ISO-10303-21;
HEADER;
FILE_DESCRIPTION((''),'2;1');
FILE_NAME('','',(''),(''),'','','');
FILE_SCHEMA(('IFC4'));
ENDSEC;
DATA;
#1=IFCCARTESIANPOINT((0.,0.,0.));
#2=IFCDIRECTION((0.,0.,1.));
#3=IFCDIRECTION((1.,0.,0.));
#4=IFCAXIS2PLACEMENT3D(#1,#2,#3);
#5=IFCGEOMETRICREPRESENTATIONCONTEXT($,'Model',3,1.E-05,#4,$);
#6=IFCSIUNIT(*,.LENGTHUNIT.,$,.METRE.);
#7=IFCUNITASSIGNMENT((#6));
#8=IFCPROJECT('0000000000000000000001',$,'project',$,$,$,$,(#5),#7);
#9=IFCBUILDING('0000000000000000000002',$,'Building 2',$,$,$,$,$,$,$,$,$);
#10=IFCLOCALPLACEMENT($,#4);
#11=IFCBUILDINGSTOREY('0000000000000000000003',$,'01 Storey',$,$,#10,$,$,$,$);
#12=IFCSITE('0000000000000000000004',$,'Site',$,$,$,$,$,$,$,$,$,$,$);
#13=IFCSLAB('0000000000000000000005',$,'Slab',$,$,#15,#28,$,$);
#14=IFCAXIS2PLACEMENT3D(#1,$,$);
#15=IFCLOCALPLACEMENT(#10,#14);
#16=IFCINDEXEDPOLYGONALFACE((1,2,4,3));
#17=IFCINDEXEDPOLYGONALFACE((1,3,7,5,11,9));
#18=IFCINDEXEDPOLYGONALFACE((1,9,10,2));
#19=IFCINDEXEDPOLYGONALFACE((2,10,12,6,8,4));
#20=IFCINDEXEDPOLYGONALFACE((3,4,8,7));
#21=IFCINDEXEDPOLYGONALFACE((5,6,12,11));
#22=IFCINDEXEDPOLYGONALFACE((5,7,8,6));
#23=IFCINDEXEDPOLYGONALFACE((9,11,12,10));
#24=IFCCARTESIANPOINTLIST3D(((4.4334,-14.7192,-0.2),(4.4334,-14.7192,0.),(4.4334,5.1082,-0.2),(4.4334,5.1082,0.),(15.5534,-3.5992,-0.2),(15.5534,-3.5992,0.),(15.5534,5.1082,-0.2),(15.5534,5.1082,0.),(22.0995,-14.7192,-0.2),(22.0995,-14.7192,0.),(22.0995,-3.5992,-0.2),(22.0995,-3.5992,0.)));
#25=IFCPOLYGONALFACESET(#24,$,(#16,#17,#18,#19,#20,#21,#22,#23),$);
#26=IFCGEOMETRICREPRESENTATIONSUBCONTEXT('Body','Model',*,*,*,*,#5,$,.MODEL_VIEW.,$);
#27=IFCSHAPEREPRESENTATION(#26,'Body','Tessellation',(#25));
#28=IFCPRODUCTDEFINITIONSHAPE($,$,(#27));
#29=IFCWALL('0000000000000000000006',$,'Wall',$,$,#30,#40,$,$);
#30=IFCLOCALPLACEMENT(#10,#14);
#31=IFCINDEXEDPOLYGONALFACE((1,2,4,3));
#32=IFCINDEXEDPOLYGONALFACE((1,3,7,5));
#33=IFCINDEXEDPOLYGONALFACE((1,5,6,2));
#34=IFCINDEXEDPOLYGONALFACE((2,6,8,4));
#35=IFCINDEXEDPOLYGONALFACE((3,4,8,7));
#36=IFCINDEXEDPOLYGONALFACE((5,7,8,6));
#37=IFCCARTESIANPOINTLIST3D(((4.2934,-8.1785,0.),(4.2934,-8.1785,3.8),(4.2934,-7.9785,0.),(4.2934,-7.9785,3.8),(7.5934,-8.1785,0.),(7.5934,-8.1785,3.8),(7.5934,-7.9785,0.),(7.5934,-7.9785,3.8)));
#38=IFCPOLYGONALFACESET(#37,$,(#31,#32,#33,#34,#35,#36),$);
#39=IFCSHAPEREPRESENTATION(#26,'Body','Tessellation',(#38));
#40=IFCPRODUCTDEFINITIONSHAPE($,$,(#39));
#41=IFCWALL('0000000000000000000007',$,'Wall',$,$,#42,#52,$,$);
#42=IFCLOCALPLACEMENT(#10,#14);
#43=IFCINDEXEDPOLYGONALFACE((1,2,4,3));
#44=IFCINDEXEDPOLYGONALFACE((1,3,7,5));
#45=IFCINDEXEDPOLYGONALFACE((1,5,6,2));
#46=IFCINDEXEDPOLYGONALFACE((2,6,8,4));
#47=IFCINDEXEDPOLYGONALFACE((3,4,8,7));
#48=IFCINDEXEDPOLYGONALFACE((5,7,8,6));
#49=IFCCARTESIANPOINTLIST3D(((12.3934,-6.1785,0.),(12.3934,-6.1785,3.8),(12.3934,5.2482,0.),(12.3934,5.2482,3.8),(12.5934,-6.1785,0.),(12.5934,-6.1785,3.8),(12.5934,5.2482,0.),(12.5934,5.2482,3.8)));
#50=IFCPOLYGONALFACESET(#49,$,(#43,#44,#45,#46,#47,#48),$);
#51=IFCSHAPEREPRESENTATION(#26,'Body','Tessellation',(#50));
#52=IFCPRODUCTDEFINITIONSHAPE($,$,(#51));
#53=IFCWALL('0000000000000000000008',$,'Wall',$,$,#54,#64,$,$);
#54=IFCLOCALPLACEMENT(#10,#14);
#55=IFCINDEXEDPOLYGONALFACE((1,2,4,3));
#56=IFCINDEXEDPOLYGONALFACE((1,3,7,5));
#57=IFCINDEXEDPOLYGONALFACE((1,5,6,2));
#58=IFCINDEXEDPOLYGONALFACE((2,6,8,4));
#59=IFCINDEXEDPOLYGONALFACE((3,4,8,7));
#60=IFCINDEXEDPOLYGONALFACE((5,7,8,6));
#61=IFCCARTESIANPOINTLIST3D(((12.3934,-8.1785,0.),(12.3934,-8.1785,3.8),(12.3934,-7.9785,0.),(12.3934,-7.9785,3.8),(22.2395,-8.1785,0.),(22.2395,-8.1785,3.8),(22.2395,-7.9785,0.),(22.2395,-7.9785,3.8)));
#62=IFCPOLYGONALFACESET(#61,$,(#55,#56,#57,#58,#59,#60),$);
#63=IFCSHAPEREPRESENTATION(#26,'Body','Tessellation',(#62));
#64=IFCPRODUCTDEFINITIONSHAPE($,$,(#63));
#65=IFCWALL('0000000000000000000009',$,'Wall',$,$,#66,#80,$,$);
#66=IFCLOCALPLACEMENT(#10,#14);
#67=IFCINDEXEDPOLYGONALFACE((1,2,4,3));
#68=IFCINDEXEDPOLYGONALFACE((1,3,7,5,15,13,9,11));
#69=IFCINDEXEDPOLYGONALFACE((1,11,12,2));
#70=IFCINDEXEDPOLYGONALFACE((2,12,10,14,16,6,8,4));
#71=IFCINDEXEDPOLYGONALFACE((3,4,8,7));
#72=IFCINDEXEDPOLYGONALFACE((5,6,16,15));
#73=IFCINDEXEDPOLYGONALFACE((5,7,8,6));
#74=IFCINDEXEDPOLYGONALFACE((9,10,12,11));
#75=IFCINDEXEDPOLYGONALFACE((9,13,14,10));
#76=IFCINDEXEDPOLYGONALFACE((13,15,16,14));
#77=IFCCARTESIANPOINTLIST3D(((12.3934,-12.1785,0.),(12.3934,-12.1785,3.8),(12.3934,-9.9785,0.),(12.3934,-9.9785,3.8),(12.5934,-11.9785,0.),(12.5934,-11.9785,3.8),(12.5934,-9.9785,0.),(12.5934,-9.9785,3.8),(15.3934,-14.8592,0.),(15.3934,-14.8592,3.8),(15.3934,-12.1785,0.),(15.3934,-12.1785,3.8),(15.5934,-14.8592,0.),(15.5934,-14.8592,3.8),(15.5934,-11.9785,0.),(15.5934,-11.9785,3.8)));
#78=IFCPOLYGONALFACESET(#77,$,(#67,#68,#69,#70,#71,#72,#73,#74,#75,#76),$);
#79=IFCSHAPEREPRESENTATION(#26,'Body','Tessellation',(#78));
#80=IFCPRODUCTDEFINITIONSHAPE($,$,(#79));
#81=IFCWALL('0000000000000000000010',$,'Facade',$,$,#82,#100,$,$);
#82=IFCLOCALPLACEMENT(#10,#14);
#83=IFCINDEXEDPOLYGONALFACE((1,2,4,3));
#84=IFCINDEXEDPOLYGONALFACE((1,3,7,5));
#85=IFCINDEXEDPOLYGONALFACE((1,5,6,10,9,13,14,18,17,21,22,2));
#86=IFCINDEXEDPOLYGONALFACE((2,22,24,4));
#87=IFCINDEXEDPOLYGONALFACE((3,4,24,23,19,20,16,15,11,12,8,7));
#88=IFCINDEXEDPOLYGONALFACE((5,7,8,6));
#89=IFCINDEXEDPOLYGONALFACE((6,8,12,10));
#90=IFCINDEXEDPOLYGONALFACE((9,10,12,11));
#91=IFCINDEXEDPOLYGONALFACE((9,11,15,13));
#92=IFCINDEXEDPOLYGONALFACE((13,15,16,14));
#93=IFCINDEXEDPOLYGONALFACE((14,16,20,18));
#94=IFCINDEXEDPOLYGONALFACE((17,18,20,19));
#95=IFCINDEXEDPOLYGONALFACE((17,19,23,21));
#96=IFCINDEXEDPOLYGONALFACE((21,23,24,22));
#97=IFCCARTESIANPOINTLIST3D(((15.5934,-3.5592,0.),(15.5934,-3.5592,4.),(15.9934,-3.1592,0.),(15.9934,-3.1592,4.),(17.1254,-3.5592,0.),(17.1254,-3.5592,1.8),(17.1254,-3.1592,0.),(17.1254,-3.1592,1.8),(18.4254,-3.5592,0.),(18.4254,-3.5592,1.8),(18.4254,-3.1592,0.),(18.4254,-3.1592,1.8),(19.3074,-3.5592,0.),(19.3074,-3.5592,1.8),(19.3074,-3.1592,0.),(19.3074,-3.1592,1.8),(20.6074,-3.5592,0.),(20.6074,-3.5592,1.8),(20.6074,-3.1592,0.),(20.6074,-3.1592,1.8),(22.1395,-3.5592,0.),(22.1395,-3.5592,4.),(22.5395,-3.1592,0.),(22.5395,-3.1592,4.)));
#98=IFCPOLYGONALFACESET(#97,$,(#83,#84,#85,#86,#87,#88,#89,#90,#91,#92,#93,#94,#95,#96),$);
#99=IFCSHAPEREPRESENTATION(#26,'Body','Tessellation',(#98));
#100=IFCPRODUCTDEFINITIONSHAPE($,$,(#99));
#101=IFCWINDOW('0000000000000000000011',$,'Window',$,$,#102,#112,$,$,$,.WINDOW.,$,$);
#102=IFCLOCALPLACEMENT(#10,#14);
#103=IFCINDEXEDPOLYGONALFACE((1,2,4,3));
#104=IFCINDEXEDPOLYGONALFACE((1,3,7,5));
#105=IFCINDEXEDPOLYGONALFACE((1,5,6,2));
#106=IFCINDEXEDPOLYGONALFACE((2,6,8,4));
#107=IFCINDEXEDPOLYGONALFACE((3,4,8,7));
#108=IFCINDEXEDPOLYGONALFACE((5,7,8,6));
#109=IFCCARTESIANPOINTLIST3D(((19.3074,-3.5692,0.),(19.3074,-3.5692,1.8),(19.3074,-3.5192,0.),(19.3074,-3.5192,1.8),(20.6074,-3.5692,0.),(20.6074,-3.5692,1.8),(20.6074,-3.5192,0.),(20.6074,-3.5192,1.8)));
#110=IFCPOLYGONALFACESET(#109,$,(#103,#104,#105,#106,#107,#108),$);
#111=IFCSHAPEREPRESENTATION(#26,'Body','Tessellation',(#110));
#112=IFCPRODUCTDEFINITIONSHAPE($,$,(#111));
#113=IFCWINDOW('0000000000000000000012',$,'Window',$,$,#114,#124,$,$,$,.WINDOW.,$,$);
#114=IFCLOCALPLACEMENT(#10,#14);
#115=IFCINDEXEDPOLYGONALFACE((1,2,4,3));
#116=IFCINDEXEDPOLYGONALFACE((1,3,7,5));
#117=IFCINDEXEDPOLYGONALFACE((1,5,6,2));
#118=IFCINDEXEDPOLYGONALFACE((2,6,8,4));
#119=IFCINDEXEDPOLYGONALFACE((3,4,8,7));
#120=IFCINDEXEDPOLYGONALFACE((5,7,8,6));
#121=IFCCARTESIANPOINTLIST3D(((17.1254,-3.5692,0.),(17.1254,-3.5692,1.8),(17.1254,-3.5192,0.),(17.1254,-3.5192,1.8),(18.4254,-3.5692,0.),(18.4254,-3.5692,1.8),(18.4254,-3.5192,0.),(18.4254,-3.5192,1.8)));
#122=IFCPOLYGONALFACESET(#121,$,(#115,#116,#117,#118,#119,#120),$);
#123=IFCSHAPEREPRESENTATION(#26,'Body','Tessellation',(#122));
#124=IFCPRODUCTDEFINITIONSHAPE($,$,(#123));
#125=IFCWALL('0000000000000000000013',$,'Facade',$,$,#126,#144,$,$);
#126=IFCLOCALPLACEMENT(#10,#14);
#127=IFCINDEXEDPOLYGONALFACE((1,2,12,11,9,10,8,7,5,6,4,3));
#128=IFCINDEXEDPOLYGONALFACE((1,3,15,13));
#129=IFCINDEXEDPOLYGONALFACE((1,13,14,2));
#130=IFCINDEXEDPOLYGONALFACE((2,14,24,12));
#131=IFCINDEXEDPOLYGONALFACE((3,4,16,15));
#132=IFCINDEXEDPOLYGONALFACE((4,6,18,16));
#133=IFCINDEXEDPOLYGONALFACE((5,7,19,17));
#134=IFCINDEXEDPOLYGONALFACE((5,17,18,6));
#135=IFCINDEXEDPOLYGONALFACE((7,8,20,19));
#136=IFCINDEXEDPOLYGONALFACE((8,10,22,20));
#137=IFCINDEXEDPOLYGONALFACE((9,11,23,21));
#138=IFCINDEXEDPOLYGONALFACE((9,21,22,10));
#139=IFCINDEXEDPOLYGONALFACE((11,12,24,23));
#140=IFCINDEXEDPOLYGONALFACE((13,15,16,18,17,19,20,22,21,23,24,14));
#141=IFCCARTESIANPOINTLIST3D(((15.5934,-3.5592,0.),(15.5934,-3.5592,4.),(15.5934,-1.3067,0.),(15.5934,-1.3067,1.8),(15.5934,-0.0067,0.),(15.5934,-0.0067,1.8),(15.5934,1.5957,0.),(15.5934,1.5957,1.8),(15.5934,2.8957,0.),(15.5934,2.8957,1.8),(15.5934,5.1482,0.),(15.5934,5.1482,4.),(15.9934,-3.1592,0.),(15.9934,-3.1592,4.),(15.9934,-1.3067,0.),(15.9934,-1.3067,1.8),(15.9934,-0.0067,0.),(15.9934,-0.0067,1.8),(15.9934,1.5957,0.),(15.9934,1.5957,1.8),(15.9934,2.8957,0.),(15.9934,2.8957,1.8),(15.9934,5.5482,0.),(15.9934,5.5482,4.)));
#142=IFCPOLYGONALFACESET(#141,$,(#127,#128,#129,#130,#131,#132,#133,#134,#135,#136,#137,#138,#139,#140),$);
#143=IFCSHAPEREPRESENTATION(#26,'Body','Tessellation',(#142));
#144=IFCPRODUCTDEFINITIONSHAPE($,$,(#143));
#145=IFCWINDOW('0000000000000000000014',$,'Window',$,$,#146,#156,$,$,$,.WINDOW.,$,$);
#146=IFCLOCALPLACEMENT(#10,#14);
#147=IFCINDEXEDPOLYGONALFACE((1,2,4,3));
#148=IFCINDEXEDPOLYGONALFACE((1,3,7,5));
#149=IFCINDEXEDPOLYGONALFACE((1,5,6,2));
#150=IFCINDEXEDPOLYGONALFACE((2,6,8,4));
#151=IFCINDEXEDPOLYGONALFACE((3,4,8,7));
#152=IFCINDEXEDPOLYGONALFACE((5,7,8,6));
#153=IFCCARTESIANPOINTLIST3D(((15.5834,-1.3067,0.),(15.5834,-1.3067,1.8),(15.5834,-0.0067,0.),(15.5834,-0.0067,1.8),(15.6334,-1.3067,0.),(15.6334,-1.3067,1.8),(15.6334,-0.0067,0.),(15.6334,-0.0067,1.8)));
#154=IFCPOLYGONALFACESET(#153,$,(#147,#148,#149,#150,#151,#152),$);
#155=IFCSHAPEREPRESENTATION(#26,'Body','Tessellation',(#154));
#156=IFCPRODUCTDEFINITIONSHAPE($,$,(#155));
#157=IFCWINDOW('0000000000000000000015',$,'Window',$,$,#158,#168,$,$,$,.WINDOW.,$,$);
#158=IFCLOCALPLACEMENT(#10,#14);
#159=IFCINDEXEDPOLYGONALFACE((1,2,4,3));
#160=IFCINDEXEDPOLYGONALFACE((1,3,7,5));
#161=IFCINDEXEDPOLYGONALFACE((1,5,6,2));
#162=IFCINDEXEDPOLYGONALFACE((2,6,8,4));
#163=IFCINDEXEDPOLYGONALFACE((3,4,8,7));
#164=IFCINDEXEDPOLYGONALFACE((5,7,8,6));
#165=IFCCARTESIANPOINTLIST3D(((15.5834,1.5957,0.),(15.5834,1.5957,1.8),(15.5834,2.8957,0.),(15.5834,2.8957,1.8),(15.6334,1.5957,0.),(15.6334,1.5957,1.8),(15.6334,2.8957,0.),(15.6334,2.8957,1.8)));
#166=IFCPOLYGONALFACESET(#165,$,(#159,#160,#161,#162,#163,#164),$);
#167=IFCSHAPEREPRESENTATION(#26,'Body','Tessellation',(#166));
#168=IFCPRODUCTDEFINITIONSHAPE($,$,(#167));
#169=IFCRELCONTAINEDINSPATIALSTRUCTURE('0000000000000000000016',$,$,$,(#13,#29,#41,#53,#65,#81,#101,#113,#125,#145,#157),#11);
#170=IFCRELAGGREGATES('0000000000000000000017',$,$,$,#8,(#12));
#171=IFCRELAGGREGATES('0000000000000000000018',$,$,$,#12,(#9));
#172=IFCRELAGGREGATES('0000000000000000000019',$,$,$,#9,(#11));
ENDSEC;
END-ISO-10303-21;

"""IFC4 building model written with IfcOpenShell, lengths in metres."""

from ifc_helpers import new_model, si_unit, origin_with_axes, place, context, subcontext, project, spatial, line, indexed_curve, outline, extrude, element, fill, save


model = new_model("IFC4")

# Units and contexts
model_context = context("Model", 3, precision=1e-05, world=origin_with_axes())
body_context = subcontext(model_context, "Body", "Model", "MODEL_VIEW")
ifc_project = project(units=[si_unit("LENGTHUNIT", "METRE")], contexts=[model_context])

# Site, building, storey
site = spatial("IfcSite", under=ifc_project, Name="Site")
building = spatial("IfcBuilding", under=site, Name="Building 2")
storey_placement = place(None, origin_with_axes())
storey = spatial("IfcBuildingStorey", under=building, at=storey_placement, Name="01 Storey")

# Slab
slab_placement = place(storey_placement, origin_with_axes())
element("IfcSlab", 1, at=slab_placement, inside=storey, Name="Slab", context=body_context, shape_type="SweptSolid", body=[
    extrude(outline(indexed_curve([(22.0995, -3.5992), (15.5534, -3.5992), (15.5534, 5.1082), (4.4334, 5.1082), (4.4334, -14.7192), (22.0995, -14.7192)], segments=[line(1, 2), line(2, 3), line(3, 4), line(4, 5), line(5, 6)])), origin_with_axes(), (0.0, 0.0, -1.0), 0.2),
])

# Walls
wall_1_placement = place(storey_placement, origin_with_axes())
element("IfcWall", 2, at=wall_1_placement, inside=storey, Name="Wall", context=body_context, shape_type="SweptSolid", body=[
    extrude(outline(indexed_curve([(7.5934, -7.9785), (4.2934, -7.9785), (4.2934, -8.1785), (7.5934, -8.1785)], segments=[line(1, 2), line(2, 3), line(3, 4)])), origin_with_axes(), (0.0, 0.0, 1.0), 3.8),
])
wall_2_placement = place(storey_placement, origin_with_axes())
element("IfcWall", 3, at=wall_2_placement, inside=storey, Name="Wall", context=body_context, shape_type="SweptSolid", body=[
    extrude(outline(indexed_curve([(12.5934, 5.2482), (12.3934, 5.2482), (12.3934, -6.1785), (12.5934, -6.1785)], segments=[line(1, 2), line(2, 3), line(3, 4)])), origin_with_axes(), (0.0, 0.0, 1.0), 3.8),
])
wall_3_placement = place(storey_placement, origin_with_axes())
element("IfcWall", 4, at=wall_3_placement, inside=storey, Name="Wall", context=body_context, shape_type="SweptSolid", body=[
    extrude(outline(indexed_curve([(22.2395, -7.9785), (12.3934, -7.9785), (12.3934, -8.1785), (22.2395, -8.1785)], segments=[line(1, 2), line(2, 3), line(3, 4)])), origin_with_axes(), (0.0, 0.0, 1.0), 3.8),
])
wall_4_placement = place(storey_placement, origin_with_axes())
element("IfcWall", 5, at=wall_4_placement, inside=storey, Name="Wall", context=body_context, shape_type="SweptSolid", body=[
    extrude(outline(indexed_curve([(15.5934, -11.9785), (12.5934, -11.9785), (12.5934, -9.9785), (12.3934, -9.9785), (12.3934, -12.1785), (15.3934, -12.1785), (15.3934, -14.8592), (15.5934, -14.8592)], segments=[line(1, 2), line(2, 3), line(3, 4), line(4, 5), line(5, 6), line(6, 7), line(7, 8)])), origin_with_axes(), (0.0, 0.0, 1.0), 3.8),
])

# Walls, openings, windows
wall_5_placement = place(storey_placement, origin_with_axes())
wall_5 = element("IfcWall", 6, at=wall_5_placement, inside=storey, Name="Facade", context=body_context, shape_type="SweptSolid", body=[
    extrude(outline(indexed_curve([(22.1395, -3.5592), (15.5934, -3.5592), (15.9934, -3.1592), (22.5395, -3.1592)], segments=[line(1, 2), line(2, 3), line(3, 4)])), origin_with_axes(), (0.0, 0.0, 1.0), 4.0),
])
opening_1_placement = place(wall_5_placement, origin_with_axes())
opening_1 = element("IfcOpeningElement", 7, at=opening_1_placement, cuts=wall_5, context=body_context, shape_type="SweptSolid", body=[
    extrude(outline(indexed_curve([(20.6074, -3.1192), (20.6074, -3.6192), (19.3074, -3.6192), (19.3074, -3.1192)], segments=[line(1, 2), line(2, 3), line(3, 4)])), origin_with_axes(), (0.0, 0.0, 1.0), 1.8),
])
opening_2_placement = place(wall_5_placement, origin_with_axes())
opening_2 = element("IfcOpeningElement", 8, at=opening_2_placement, cuts=wall_5, context=body_context, shape_type="SweptSolid", body=[
    extrude(outline(indexed_curve([(18.4254, -3.1192), (18.4254, -3.6192), (17.1254, -3.6192), (17.1254, -3.1192)], segments=[line(1, 2), line(2, 3), line(3, 4)])), origin_with_axes(), (0.0, 0.0, 1.0), 1.8),
])
window_1_placement = place(storey_placement, origin_with_axes())
window_1 = element("IfcWindow", 9, at=window_1_placement, inside=storey, Name="Window", PredefinedType="WINDOW", context=body_context, shape_type="SweptSolid", body=[
    extrude(outline(indexed_curve([(20.6074, -3.5192), (20.6074, -3.5692), (19.3074, -3.5692), (19.3074, -3.5192)], segments=[line(1, 2), line(2, 3), line(3, 4)])), origin_with_axes(), (0.0, 0.0, 1.0), 1.8),
])
fill(opening_1, window_1)
window_2_placement = place(storey_placement, origin_with_axes())
window_2 = element("IfcWindow", 10, at=window_2_placement, inside=storey, Name="Window", PredefinedType="WINDOW", context=body_context, shape_type="SweptSolid", body=[
    extrude(outline(indexed_curve([(18.4254, -3.5192), (18.4254, -3.5692), (17.1254, -3.5692), (17.1254, -3.5192)], segments=[line(1, 2), line(2, 3), line(3, 4)])), origin_with_axes(), (0.0, 0.0, 1.0), 1.8),
])
fill(opening_2, window_2)
wall_6_placement = place(storey_placement, origin_with_axes())
wall_6 = element("IfcWall", 11, at=wall_6_placement, inside=storey, Name="Facade", context=body_context, shape_type="SweptSolid", body=[
    extrude(outline(indexed_curve([(15.5934, -3.5592), (15.5934, 5.1482), (15.9934, 5.5482), (15.9934, -3.1592)], segments=[line(1, 2), line(2, 3), line(3, 4)])), origin_with_axes(), (0.0, 0.0, 1.0), 4.0),
])
opening_3_placement = place(wall_6_placement, origin_with_axes())
opening_3 = element("IfcOpeningElement", 12, at=opening_3_placement, cuts=wall_6, context=body_context, shape_type="SweptSolid", body=[
    extrude(outline(indexed_curve([(16.0334, -1.3067), (15.5334, -1.3067), (15.5334, -0.0067), (16.0334, -0.0067)], segments=[line(1, 2), line(2, 3), line(3, 4)])), origin_with_axes(), (0.0, 0.0, 1.0), 1.8),
])
opening_4_placement = place(wall_6_placement, origin_with_axes())
opening_4 = element("IfcOpeningElement", 13, at=opening_4_placement, cuts=wall_6, context=body_context, shape_type="SweptSolid", body=[
    extrude(outline(indexed_curve([(16.0334, 1.5957), (15.5334, 1.5957), (15.5334, 2.8957), (16.0334, 2.8957)], segments=[line(1, 2), line(2, 3), line(3, 4)])), origin_with_axes(), (0.0, 0.0, 1.0), 1.8),
])
window_3_placement = place(storey_placement, origin_with_axes())
window_3 = element("IfcWindow", 14, at=window_3_placement, inside=storey, Name="Window", PredefinedType="WINDOW", context=body_context, shape_type="SweptSolid", body=[
    extrude(outline(indexed_curve([(15.6334, -1.3067), (15.5834, -1.3067), (15.5834, -0.0067), (15.6334, -0.0067)], segments=[line(1, 2), line(2, 3), line(3, 4)])), origin_with_axes(), (0.0, 0.0, 1.0), 1.8),
])
fill(opening_3, window_3)
window_4_placement = place(storey_placement, origin_with_axes())
window_4 = element("IfcWindow", 15, at=window_4_placement, inside=storey, Name="Window", PredefinedType="WINDOW", context=body_context, shape_type="SweptSolid", body=[
    extrude(outline(indexed_curve([(15.6334, 1.5957), (15.5834, 1.5957), (15.5834, 2.8957), (15.6334, 2.8957)], segments=[line(1, 2), line(2, 3), line(3, 4)])), origin_with_axes(), (0.0, 0.0, 1.0), 1.8),
])
fill(opening_4, window_4)

save(model, "model.ifc")
